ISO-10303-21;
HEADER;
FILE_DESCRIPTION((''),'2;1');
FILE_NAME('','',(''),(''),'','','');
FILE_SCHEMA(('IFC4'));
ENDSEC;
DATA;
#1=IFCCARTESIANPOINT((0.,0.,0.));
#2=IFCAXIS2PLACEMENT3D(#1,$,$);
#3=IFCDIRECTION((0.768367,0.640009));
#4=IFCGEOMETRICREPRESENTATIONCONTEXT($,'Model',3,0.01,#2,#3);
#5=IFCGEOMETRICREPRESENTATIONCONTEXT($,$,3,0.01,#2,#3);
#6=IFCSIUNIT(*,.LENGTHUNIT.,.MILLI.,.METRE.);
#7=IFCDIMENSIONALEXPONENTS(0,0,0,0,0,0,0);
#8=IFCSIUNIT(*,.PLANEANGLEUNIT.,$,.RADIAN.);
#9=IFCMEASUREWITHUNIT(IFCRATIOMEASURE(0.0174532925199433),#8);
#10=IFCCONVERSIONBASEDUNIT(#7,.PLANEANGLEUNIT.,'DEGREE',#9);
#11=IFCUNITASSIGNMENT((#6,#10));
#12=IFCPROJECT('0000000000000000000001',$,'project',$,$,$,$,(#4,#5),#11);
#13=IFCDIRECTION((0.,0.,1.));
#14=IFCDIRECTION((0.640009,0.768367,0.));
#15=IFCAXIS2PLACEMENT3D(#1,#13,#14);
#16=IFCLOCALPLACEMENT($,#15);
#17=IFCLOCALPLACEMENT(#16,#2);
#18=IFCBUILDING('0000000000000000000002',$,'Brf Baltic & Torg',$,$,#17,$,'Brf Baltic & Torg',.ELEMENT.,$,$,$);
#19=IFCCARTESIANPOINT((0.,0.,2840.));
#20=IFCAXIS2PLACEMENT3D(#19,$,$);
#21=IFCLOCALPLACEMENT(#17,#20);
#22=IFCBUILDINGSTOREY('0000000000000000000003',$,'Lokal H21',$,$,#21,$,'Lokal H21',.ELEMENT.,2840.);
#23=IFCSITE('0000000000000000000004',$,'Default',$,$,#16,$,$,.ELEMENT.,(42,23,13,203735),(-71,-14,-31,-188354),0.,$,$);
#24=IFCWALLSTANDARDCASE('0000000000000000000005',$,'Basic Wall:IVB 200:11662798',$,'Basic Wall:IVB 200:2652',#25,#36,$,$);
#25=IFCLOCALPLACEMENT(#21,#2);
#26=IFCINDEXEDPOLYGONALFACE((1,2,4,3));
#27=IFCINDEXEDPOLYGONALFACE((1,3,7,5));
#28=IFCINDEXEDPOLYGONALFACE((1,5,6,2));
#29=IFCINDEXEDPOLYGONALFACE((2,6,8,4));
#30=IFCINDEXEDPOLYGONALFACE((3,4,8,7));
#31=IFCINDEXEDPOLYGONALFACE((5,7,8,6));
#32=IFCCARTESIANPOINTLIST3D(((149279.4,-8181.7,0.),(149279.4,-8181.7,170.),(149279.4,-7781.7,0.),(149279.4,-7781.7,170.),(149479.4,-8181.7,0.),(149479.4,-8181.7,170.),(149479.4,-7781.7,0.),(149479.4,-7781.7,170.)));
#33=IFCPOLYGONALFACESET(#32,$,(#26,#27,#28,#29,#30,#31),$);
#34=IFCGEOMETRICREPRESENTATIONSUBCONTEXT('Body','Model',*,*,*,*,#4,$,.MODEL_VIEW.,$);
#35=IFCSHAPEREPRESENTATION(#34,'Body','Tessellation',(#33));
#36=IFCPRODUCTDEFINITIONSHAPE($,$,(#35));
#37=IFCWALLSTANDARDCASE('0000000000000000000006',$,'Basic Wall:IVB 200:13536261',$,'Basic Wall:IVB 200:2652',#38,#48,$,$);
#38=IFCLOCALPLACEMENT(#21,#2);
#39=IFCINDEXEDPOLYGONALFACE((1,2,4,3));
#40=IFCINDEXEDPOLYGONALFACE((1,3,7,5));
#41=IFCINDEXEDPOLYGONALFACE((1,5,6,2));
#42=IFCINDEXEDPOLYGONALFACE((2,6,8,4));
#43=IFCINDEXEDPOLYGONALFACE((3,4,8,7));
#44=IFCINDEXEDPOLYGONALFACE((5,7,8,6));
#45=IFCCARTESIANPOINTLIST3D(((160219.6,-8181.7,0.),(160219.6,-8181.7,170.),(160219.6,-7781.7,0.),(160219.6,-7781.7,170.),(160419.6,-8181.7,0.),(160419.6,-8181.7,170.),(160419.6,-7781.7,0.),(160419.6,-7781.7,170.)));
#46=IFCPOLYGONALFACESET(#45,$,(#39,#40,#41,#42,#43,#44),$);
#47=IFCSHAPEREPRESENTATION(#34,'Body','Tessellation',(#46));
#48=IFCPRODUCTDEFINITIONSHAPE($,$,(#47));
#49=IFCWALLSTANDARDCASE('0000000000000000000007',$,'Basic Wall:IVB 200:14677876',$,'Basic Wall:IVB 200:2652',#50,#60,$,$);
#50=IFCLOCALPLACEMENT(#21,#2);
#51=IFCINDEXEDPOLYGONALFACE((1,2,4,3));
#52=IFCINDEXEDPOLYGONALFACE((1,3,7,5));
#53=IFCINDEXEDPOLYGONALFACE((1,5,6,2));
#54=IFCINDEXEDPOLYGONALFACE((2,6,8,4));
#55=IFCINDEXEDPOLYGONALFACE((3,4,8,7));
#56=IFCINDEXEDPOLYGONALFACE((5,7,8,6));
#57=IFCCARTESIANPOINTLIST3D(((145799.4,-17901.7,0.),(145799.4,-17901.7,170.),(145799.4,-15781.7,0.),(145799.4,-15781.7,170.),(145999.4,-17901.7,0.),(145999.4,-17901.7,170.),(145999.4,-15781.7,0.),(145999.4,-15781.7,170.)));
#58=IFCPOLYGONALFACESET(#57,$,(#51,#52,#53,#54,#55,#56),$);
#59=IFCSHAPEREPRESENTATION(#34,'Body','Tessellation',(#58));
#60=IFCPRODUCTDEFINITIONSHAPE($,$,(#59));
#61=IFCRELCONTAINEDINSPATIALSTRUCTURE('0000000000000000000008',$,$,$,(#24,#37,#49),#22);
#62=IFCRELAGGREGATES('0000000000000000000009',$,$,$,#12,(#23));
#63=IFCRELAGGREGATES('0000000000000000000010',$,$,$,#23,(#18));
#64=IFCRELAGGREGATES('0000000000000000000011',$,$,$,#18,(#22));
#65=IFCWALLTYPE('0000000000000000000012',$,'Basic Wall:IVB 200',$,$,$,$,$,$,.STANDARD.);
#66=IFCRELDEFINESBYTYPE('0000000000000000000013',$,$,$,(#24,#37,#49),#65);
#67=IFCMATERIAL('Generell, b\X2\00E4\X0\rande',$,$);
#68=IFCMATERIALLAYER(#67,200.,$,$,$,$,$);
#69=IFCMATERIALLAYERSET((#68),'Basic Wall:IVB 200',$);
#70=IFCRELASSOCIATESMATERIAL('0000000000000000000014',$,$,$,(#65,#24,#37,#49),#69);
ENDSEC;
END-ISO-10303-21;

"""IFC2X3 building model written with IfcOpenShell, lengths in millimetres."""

from ifc_helpers import new_model, entity, si_unit, converted_unit, direction, frame, frame_2d, origin, place, context, subcontext, project, spatial, rectangle, extrude, clip, halfspace, material, layer, layer_set, layer_usage, type_object, element, save


model = new_model("IFC2X3")

# Units and contexts
model_context = context("Model", 3, precision=0.01, world=origin(), true_north=direction((0.768367, 0.640009)))
context_of_model = context(None, 3, precision=0.01, world=origin(), true_north=direction((0.768367, 0.640009)))
body_context = subcontext(model_context, "Body", "Model", "MODEL_VIEW")
ifc_project = project(units=[si_unit("LENGTHUNIT", "METRE", prefix="MILLI"), converted_unit("PLANEANGLEUNIT", "DEGREE", entity("IfcRatioMeasure", 0.0174532925199433), si_unit("PLANEANGLEUNIT", "RADIAN"), dimensions=[0, 0, 0, 0, 0, 0, 0])], contexts=[model_context, context_of_model])

# Site, building, storey
site_placement = place(None, frame((0.0, 0.0, 0.0), z_axis=(0.0, 0.0, 1.0), x_axis=(0.640009, 0.768367, 0.0)))
site = spatial("IfcSite", under=ifc_project, at=site_placement, Name="Default", CompositionType="ELEMENT", RefLatitude=(42, 23, 13, 203735), RefLongitude=(-71, -14, -31, -188354), RefElevation=0.0)
building_placement = place(site_placement, origin())
building = spatial("IfcBuilding", under=site, at=building_placement, Name="Brf Baltic & Torg", LongName="Brf Baltic & Torg", CompositionType="ELEMENT")
storey_placement = place(building_placement, frame((0.0, 0.0, 2840.0)))
storey = spatial("IfcBuildingStorey", under=building, at=storey_placement, Name="Lokal H21", LongName="Lokal H21", CompositionType="ELEMENT", Elevation=2840.0)

# Shared definitions
ifc_material_1 = material(Name="Generell, bärande")
ifc_layer = layer(ifc_material_1, 200.0)
ifc_layer_set = layer_set([ifc_layer], Name="Basic Wall:IVB 200")
wall_type = type_object("IfcWallType", Name="Basic Wall:IVB 200", PredefinedType="STANDARD", material=ifc_layer_set)

# Walls
ifc_layer_usage_1 = layer_usage(ifc_layer_set, "AXIS2", "NEGATIVE", 100.0)
wall_1_placement = place(storey_placement, frame((149379.4, -8181.7, 0.0), z_axis=(0.0, 0.0, 1.0), x_axis=(0.0, 1.0, 0.0)))
element("IfcWallStandardCase", 1, at=wall_1_placement, inside=storey, type_object=wall_type, material=ifc_layer_usage_1, Name="Basic Wall:IVB 200:11662798", ObjectType="Basic Wall:IVB 200:2652", context=body_context, shape_type="Clipping", body=[
    clip(extrude(rectangle(XDim=400.0, YDim=200.0, at=frame_2d((200.0, 0.0), x_axis=(-1.0, 0.0))), origin(), (0.0, 0.0, 1.0), 170.0), halfspace(frame((0.0, 0.0, -1190.0)), True)),
])
ifc_layer_usage_2 = layer_usage(ifc_layer_set, "AXIS2", "NEGATIVE", 100.0)
wall_2_placement = place(storey_placement, frame((160319.6, -8181.7, 0.0), z_axis=(0.0, 0.0, 1.0), x_axis=(0.0, 1.0, 0.0)))
element("IfcWallStandardCase", 2, at=wall_2_placement, inside=storey, type_object=wall_type, material=ifc_layer_usage_2, Name="Basic Wall:IVB 200:13536261", ObjectType="Basic Wall:IVB 200:2652", context=body_context, shape_type="Clipping", body=[
    clip(extrude(rectangle(XDim=400.0, YDim=200.0, at=frame_2d((200.0, 0.0), x_axis=(-1.0, 0.0))), origin(), (0.0, 0.0, 1.0), 170.0), halfspace(frame((0.0, 0.0, -1190.0)), True)),
])

# Wall
ifc_layer_usage_3 = layer_usage(ifc_layer_set, "AXIS2", "POSITIVE", -100.0)
wall_3_placement = place(storey_placement, frame((145899.4, -15781.7, 0.0), z_axis=(0.0, 0.0, 1.0), x_axis=(0.0, -1.0, 0.0)))
element("IfcWallStandardCase", 3, at=wall_3_placement, inside=storey, type_object=wall_type, material=ifc_layer_usage_3, Name="Basic Wall:IVB 200:14677876", ObjectType="Basic Wall:IVB 200:2652", context=body_context, shape_type="Clipping", body=[
    clip(extrude(rectangle(XDim=2120.0, YDim=200.0, at=frame_2d((1060.0, 0.0), x_axis=(-1.0, 0.0))), origin(), (0.0, 0.0, 1.0), 170.0), halfspace(frame((0.0, 0.0, -1190.0)), True)),
])

save(model, "model.ifc")
